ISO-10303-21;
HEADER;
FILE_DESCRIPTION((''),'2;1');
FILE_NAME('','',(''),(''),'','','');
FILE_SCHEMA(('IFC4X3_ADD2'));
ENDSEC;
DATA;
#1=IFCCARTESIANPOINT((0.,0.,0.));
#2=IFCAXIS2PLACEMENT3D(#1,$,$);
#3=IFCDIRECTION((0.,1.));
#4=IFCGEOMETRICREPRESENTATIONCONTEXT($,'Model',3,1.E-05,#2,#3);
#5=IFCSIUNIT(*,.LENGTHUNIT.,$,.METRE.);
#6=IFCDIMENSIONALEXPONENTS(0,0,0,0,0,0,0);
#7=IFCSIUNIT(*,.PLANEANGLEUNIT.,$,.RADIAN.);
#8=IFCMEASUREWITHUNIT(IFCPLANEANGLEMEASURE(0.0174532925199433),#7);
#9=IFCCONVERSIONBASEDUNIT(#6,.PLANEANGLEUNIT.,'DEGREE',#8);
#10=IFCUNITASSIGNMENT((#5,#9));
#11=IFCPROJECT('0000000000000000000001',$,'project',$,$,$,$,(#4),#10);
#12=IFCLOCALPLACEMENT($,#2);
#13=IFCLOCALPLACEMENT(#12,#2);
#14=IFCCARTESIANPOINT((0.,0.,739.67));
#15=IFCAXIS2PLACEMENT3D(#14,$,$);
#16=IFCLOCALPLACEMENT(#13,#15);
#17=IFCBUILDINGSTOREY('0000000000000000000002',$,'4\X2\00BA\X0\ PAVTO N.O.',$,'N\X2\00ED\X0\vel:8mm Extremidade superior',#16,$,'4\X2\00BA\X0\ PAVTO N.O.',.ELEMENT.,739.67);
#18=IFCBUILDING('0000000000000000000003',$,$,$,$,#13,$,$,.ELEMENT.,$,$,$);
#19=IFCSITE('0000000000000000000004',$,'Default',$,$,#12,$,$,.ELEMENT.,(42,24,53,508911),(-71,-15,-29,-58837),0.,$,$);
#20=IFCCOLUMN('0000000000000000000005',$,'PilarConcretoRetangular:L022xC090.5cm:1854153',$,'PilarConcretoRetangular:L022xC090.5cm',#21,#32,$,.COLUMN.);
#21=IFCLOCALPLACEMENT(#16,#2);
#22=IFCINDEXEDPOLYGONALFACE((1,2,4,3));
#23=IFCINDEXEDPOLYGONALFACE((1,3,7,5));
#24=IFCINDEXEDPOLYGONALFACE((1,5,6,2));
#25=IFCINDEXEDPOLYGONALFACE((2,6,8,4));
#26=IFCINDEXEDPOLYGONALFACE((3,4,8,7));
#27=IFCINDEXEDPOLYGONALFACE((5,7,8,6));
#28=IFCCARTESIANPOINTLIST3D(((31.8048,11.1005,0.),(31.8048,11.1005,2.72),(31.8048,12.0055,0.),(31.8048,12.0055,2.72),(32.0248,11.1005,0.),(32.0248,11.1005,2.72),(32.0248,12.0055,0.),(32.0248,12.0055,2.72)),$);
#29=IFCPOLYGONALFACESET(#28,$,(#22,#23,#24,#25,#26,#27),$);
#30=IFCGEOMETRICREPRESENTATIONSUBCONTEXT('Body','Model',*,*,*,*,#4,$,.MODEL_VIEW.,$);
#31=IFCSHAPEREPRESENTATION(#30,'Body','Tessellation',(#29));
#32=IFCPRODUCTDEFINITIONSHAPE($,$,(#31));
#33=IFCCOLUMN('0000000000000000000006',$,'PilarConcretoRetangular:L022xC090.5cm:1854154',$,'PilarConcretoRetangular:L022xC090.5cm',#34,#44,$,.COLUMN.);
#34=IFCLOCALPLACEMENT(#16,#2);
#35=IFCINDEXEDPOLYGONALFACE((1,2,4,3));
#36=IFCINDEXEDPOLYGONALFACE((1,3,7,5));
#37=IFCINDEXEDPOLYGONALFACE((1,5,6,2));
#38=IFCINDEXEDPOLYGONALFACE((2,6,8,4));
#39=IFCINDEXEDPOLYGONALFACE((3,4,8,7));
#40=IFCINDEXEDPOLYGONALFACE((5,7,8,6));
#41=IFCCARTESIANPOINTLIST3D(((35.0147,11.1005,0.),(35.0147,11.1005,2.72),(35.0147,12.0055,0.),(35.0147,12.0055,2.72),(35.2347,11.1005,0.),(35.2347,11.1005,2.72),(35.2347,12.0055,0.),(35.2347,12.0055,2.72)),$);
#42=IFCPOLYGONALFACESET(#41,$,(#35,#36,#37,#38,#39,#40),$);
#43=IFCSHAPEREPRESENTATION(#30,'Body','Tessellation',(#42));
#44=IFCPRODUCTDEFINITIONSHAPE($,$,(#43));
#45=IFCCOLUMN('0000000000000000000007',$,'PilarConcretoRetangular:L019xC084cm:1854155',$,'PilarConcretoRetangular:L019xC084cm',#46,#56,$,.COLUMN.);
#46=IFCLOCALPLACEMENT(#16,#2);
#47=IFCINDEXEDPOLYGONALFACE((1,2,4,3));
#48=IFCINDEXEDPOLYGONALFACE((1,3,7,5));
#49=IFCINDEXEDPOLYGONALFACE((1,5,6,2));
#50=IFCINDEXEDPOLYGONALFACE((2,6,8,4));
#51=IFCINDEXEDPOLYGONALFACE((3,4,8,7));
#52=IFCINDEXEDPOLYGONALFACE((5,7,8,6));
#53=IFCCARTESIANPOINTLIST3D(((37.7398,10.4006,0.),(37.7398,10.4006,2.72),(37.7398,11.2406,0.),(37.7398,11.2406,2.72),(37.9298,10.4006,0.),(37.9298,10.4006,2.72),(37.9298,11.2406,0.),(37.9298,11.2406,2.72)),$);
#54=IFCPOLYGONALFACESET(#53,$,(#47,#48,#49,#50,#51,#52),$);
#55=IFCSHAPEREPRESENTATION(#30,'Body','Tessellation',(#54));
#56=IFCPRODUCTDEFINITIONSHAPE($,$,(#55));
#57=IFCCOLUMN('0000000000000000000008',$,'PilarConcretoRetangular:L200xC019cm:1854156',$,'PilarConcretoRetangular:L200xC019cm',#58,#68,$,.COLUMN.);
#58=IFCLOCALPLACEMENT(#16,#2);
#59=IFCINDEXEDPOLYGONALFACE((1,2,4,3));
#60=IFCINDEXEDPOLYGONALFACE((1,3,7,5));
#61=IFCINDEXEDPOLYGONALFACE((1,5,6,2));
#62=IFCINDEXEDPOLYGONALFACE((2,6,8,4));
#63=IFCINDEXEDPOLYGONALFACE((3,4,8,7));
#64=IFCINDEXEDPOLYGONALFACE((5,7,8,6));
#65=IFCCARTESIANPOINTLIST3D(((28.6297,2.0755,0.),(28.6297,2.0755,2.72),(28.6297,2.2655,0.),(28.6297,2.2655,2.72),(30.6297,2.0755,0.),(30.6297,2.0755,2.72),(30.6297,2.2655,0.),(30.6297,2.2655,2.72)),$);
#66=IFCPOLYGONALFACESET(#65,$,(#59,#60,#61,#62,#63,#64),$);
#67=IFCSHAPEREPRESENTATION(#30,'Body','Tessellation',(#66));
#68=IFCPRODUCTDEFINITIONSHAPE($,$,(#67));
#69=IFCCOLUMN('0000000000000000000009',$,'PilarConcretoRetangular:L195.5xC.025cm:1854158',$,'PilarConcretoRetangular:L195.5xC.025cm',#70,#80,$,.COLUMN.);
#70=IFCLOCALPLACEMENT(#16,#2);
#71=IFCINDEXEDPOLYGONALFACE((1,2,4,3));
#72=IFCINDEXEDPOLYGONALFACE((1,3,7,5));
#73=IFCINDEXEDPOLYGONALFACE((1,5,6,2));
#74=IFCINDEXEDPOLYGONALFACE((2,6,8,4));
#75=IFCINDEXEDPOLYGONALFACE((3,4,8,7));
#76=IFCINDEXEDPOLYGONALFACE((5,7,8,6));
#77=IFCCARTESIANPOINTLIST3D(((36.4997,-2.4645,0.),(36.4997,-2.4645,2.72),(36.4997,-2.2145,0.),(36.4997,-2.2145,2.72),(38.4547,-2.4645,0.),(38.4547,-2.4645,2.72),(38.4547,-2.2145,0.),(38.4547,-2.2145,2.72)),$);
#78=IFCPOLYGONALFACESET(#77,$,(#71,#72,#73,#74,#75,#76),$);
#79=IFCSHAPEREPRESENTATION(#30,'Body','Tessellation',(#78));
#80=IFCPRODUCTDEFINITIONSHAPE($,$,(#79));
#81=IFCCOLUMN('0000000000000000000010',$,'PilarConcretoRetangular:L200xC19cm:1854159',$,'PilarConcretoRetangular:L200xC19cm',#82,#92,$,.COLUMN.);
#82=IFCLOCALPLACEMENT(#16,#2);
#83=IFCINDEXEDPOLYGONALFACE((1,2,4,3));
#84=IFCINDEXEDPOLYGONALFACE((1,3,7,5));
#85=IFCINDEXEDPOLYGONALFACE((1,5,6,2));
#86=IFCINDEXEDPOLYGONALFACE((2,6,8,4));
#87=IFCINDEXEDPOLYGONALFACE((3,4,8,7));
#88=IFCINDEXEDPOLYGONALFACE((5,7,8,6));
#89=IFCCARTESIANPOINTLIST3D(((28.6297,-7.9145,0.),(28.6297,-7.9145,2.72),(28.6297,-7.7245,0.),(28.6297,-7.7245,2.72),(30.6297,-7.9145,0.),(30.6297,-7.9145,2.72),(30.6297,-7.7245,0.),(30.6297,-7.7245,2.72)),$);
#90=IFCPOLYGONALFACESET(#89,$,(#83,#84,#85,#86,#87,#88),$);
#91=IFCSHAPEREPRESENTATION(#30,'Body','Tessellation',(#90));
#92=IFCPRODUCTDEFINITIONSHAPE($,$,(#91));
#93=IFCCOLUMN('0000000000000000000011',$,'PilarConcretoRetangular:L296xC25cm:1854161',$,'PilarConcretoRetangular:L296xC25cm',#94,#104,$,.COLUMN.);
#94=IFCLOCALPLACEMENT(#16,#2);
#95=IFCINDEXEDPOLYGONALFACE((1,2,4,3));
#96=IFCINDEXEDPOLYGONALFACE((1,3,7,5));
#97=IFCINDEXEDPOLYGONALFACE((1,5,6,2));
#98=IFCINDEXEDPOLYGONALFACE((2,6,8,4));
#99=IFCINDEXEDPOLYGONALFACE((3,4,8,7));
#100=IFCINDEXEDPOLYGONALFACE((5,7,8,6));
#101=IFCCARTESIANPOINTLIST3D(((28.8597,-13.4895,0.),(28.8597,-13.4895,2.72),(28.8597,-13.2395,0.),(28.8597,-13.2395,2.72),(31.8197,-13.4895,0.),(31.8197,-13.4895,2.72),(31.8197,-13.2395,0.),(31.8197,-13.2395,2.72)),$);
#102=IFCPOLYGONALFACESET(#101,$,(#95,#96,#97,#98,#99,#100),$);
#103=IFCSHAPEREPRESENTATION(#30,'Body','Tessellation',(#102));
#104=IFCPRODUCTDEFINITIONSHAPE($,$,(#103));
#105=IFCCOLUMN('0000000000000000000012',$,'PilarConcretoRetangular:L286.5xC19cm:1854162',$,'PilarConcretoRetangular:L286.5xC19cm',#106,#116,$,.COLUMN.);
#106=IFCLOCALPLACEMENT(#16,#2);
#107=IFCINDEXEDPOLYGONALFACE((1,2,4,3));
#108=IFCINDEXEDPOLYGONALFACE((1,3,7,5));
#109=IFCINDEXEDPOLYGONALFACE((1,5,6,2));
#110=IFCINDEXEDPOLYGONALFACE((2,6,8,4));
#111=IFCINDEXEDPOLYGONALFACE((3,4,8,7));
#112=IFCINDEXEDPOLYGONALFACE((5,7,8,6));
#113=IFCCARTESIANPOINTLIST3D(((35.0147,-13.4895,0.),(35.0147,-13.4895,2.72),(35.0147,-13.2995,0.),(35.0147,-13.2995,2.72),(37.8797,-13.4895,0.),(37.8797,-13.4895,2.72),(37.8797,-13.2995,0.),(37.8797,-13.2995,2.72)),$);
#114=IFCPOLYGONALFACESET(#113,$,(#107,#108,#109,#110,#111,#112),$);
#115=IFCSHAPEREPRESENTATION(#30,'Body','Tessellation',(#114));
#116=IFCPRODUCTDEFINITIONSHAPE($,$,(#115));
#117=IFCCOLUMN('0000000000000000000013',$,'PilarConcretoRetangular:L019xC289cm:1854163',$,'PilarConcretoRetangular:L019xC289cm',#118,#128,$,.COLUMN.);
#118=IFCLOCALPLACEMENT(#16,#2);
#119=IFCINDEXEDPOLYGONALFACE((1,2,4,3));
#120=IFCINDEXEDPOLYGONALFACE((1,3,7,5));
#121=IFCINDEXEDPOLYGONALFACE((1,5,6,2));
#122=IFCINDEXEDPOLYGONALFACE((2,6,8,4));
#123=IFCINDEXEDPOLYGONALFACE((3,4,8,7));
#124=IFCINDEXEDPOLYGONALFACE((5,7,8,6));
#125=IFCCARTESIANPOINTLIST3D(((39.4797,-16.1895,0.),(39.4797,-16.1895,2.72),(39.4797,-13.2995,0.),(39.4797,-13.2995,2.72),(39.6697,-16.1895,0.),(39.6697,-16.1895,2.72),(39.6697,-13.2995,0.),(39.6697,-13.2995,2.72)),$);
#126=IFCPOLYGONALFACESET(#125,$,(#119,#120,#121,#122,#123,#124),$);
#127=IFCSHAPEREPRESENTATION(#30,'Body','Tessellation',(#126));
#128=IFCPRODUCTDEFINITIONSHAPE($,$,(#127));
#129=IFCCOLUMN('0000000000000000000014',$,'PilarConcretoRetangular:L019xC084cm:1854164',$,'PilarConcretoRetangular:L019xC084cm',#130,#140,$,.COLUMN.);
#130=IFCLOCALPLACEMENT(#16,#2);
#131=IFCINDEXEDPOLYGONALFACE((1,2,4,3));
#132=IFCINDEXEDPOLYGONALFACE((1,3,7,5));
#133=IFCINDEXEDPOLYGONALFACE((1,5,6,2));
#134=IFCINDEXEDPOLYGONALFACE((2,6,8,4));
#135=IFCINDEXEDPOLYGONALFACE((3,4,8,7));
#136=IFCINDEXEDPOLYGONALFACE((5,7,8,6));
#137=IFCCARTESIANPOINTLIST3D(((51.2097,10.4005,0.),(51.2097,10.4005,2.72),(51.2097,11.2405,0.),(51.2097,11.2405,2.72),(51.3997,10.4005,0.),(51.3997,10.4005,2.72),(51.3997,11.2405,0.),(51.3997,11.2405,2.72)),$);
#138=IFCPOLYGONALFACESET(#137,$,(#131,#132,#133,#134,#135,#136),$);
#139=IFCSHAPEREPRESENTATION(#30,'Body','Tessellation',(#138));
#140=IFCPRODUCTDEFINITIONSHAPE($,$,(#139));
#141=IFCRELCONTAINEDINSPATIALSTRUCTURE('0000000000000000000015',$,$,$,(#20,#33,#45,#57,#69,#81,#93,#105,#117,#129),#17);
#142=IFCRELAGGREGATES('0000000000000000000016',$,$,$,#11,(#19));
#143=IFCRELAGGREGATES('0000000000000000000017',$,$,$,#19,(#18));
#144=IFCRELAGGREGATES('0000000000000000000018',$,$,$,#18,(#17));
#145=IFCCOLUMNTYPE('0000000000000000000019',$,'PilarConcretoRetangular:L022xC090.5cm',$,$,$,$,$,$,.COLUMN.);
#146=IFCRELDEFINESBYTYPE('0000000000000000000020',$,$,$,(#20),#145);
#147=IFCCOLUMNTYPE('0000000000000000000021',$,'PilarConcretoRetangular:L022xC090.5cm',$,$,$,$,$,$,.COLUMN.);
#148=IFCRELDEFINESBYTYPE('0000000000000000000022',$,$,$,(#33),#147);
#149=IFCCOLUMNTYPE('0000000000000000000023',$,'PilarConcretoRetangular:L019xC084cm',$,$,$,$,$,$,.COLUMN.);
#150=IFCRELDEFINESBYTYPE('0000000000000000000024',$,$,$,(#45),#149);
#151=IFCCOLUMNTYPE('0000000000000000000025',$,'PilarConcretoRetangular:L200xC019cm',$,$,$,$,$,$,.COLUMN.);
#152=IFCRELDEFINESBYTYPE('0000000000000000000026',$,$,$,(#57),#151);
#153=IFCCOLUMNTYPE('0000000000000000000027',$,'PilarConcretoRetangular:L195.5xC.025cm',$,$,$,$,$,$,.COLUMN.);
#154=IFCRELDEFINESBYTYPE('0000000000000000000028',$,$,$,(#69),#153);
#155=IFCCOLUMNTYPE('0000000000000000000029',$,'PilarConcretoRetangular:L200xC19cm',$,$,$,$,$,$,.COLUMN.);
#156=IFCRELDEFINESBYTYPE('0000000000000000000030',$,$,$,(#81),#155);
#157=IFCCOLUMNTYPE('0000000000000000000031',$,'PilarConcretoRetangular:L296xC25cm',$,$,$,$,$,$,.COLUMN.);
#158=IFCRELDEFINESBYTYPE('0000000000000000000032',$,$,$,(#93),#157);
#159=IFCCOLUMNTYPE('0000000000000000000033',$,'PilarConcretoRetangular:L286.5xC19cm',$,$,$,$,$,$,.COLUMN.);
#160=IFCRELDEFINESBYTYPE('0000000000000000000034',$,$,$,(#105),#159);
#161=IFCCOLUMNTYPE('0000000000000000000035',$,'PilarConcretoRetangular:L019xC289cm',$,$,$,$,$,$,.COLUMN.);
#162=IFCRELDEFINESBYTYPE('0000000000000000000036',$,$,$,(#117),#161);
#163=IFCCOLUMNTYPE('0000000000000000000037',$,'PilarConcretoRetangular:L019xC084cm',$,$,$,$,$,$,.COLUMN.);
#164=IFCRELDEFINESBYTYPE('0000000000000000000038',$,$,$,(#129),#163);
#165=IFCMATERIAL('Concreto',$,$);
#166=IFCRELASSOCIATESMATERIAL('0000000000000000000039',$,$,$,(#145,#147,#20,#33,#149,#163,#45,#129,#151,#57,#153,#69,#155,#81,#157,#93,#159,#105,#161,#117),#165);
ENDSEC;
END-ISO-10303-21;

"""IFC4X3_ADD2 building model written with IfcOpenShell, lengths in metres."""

from ifc_helpers import new_model, entity, si_unit, converted_unit, direction, frame, frame_2d, origin, origin_2d_with_axis, place, context, subcontext, project, spatial, rectangle, extrude, source, transform, mapped, material, material_profile, profile_set, profile_usage, type_object, type_shapes, element, save


model = new_model("IFC4X3_ADD2")

# Units and contexts
model_context = context("Model", 3, precision=1e-05, world=origin(), true_north=direction((0.0, 1.0)))
body_context = subcontext(model_context, "Body", "Model", "MODEL_VIEW")
ifc_project = project(units=[si_unit("LENGTHUNIT", "METRE"), converted_unit("PLANEANGLEUNIT", "DEGREE", entity("IfcPlaneAngleMeasure", 0.0174532925199433), si_unit("PLANEANGLEUNIT", "RADIAN"), dimensions=[0, 0, 0, 0, 0, 0, 0])], contexts=[model_context])

# Site, building, storey
site_placement = place(None, origin())
site = spatial("IfcSite", under=ifc_project, at=site_placement, Name="Default", CompositionType="ELEMENT", RefLatitude=(42, 24, 53, 508911), RefLongitude=(-71, -15, -29, -58837), RefElevation=0.0)
building_placement = place(site_placement, origin())
building = spatial("IfcBuilding", under=site, at=building_placement, CompositionType="ELEMENT")
storey_placement = place(building_placement, frame((0.0, 0.0, 739.67)))
storey = spatial("IfcBuildingStorey", under=building, at=storey_placement, Name="4º PAVTO N.O.", ObjectType="Nível:8mm Extremidade superior", LongName="4º PAVTO N.O.", CompositionType="ELEMENT", Elevation=739.67)

# Columns
ifc_material = material(Name="Concreto")
ifc_material_profile_1 = material_profile(ifc_material, rectangle(XDim=0.22, YDim=0.905, at=frame_2d((0.0, 0.0), x_axis=(1.0, 0.0))), Name="L022xC090.5cm")
ifc_profile_set_1 = profile_set([ifc_material_profile_1], Name="L022xC090.5cm")
ifc_profile_usage_1 = profile_usage(ifc_profile_set_1)
column_type_1 = type_object("IfcColumnType", Name="PilarConcretoRetangular:L022xC090.5cm", PredefinedType="COLUMN", material=ifc_profile_set_1)
shared_shape_1 = source(origin(), body_context, "Body", "SweptSolid", [
    extrude(rectangle(XDim=0.22, YDim=0.905, at=frame_2d((0.0, 0.0), x_axis=(1.0, 0.0))), frame((31.9148, 11.553, 739.67), z_axis=(0.0, 0.0, 1.0), x_axis=(-1.0, 0.0, 0.0)), (0.0, 0.0, 1.0), 2.72),
])
type_shapes(column_type_1, [shared_shape_1])
column_1_placement = place(storey_placement, frame((0.0, 0.0, -739.67)))
element("IfcColumn", 1, at=column_1_placement, inside=storey, type_object=column_type_1, material=ifc_profile_usage_1, Name="PilarConcretoRetangular:L022xC090.5cm:1854153", ObjectType="PilarConcretoRetangular:L022xC090.5cm", PredefinedType="COLUMN", context=body_context, shape_type="MappedRepresentation", body=[
    mapped(shared_shape_1, transform((0.0, 0.0, 0.0), scale=1.0)),
])
column_type_2 = type_object("IfcColumnType", Name="PilarConcretoRetangular:L022xC090.5cm", PredefinedType="COLUMN", material=ifc_profile_set_1)
shared_shape_2 = source(origin(), body_context, "Body", "SweptSolid", [
    extrude(rectangle(XDim=0.22, YDim=0.905, at=frame_2d((0.0, 0.0), x_axis=(1.0, 0.0))), frame((35.1247, 11.553, 739.67), z_axis=(0.0, 0.0, 1.0), x_axis=(-1.0, 0.0, 0.0)), (0.0, 0.0, 1.0), 2.72),
])
type_shapes(column_type_2, [shared_shape_2])
column_2_placement = place(storey_placement, frame((0.0, 0.0, -739.67)))
element("IfcColumn", 2, at=column_2_placement, inside=storey, type_object=column_type_2, material=ifc_profile_usage_1, Name="PilarConcretoRetangular:L022xC090.5cm:1854154", ObjectType="PilarConcretoRetangular:L022xC090.5cm", PredefinedType="COLUMN", context=body_context, shape_type="MappedRepresentation", body=[
    mapped(shared_shape_2, transform((0.0, 0.0, 0.0), scale=1.0)),
])
ifc_material_profile_2 = material_profile(ifc_material, rectangle(XDim=0.19, YDim=0.84, at=frame_2d((0.0, 0.0), x_axis=(1.0, 0.0))), Name="L019xC084cm")
ifc_profile_set_2 = profile_set([ifc_material_profile_2], Name="L019xC084cm")
ifc_profile_usage_2 = profile_usage(ifc_profile_set_2)
column_type_3 = type_object("IfcColumnType", Name="PilarConcretoRetangular:L019xC084cm", PredefinedType="COLUMN", material=ifc_profile_set_2)
shared_shape_3 = source(origin(), body_context, "Body", "SweptSolid", [
    extrude(rectangle(XDim=0.19, YDim=0.84, at=origin_2d_with_axis()), frame((37.8348, 10.8206, 739.67), z_axis=(0.0, 0.0, 1.0), x_axis=(-1.0, 0.0, 0.0)), (0.0, 0.0, 1.0), 2.72),
])
type_shapes(column_type_3, [shared_shape_3])
column_3_placement = place(storey_placement, frame((0.0, 0.0, -739.67)))
element("IfcColumn", 3, at=column_3_placement, inside=storey, type_object=column_type_3, material=ifc_profile_usage_2, Name="PilarConcretoRetangular:L019xC084cm:1854155", ObjectType="PilarConcretoRetangular:L019xC084cm", PredefinedType="COLUMN", context=body_context, shape_type="MappedRepresentation", body=[
    mapped(shared_shape_3, transform((0.0, 0.0, 0.0), scale=1.0)),
])
ifc_material_profile_3 = material_profile(ifc_material, rectangle(XDim=2.0, YDim=0.19, at=frame_2d((0.0, 0.0), x_axis=(1.0, 0.0))), Name="L200xC019cm")
ifc_profile_set_3 = profile_set([ifc_material_profile_3], Name="L200xC019cm")
ifc_profile_usage_3 = profile_usage(ifc_profile_set_3)
column_type_4 = type_object("IfcColumnType", Name="PilarConcretoRetangular:L200xC019cm", PredefinedType="COLUMN", material=ifc_profile_set_3)
shared_shape_4 = source(origin(), body_context, "Body", "SweptSolid", [
    extrude(rectangle(XDim=2.0, YDim=0.19, at=frame_2d((0.0, 0.0), x_axis=(1.0, 0.0))), frame((29.6297, 2.1705, 739.67)), (0.0, 0.0, 1.0), 2.72),
])
type_shapes(column_type_4, [shared_shape_4])
column_4_placement = place(storey_placement, frame((0.0, 0.0, -739.67)))
element("IfcColumn", 4, at=column_4_placement, inside=storey, type_object=column_type_4, material=ifc_profile_usage_3, Name="PilarConcretoRetangular:L200xC019cm:1854156", ObjectType="PilarConcretoRetangular:L200xC019cm", PredefinedType="COLUMN", context=body_context, shape_type="MappedRepresentation", body=[
    mapped(shared_shape_4, transform((0.0, 0.0, 0.0), scale=1.0)),
])
ifc_material_profile_4 = material_profile(ifc_material, rectangle(XDim=1.955, YDim=0.25, at=frame_2d((0.0, 0.0), x_axis=(1.0, 0.0))), Name="L195.5xC.025cm")
ifc_profile_set_4 = profile_set([ifc_material_profile_4], Name="L195.5xC.025cm")
ifc_profile_usage_4 = profile_usage(ifc_profile_set_4)
column_type_5 = type_object("IfcColumnType", Name="PilarConcretoRetangular:L195.5xC.025cm", PredefinedType="COLUMN", material=ifc_profile_set_4)
shared_shape_5 = source(origin(), body_context, "Body", "SweptSolid", [
    extrude(rectangle(XDim=1.955, YDim=0.25, at=frame_2d((0.0, 0.0), x_axis=(1.0, 0.0))), frame((37.4772, -2.3395, 739.67)), (0.0, 0.0, 1.0), 2.72),
])
type_shapes(column_type_5, [shared_shape_5])
column_5_placement = place(storey_placement, frame((0.0, 0.0, -739.67)))
element("IfcColumn", 5, at=column_5_placement, inside=storey, type_object=column_type_5, material=ifc_profile_usage_4, Name="PilarConcretoRetangular:L195.5xC.025cm:1854158", ObjectType="PilarConcretoRetangular:L195.5xC.025cm", PredefinedType="COLUMN", context=body_context, shape_type="MappedRepresentation", body=[
    mapped(shared_shape_5, transform((0.0, 0.0, 0.0), scale=1.0)),
])
ifc_material_profile_5 = material_profile(ifc_material, rectangle(XDim=2.0, YDim=0.19, at=frame_2d((0.0, 0.0), x_axis=(1.0, 0.0))), Name="L200xC19cm")
ifc_profile_set_5 = profile_set([ifc_material_profile_5], Name="L200xC19cm")
ifc_profile_usage_5 = profile_usage(ifc_profile_set_5)
column_type_6 = type_object("IfcColumnType", Name="PilarConcretoRetangular:L200xC19cm", PredefinedType="COLUMN", material=ifc_profile_set_5)
shared_shape_6 = source(origin(), body_context, "Body", "SweptSolid", [
    extrude(rectangle(XDim=2.0, YDim=0.19, at=frame_2d((0.0, 0.0), x_axis=(1.0, 0.0))), frame((29.6297, -7.8195, 739.67)), (0.0, 0.0, 1.0), 2.72),
])
type_shapes(column_type_6, [shared_shape_6])
column_6_placement = place(storey_placement, frame((0.0, 0.0, -739.67)))
element("IfcColumn", 6, at=column_6_placement, inside=storey, type_object=column_type_6, material=ifc_profile_usage_5, Name="PilarConcretoRetangular:L200xC19cm:1854159", ObjectType="PilarConcretoRetangular:L200xC19cm", PredefinedType="COLUMN", context=body_context, shape_type="MappedRepresentation", body=[
    mapped(shared_shape_6, transform((0.0, 0.0, 0.0), scale=1.0)),
])
ifc_material_profile_6 = material_profile(ifc_material, rectangle(XDim=2.96, YDim=0.25, at=frame_2d((0.0, 0.0), x_axis=(1.0, 0.0))), Name="L296xC25cm")
ifc_profile_set_6 = profile_set([ifc_material_profile_6], Name="L296xC25cm")
ifc_profile_usage_6 = profile_usage(ifc_profile_set_6)
column_type_7 = type_object("IfcColumnType", Name="PilarConcretoRetangular:L296xC25cm", PredefinedType="COLUMN", material=ifc_profile_set_6)
shared_shape_7 = source(origin(), body_context, "Body", "SweptSolid", [
    extrude(rectangle(XDim=2.96, YDim=0.25, at=frame_2d((0.0, 0.0), x_axis=(1.0, 0.0))), frame((30.3397, -13.3645, 739.67)), (0.0, 0.0, 1.0), 2.72),
])
type_shapes(column_type_7, [shared_shape_7])
column_7_placement = place(storey_placement, frame((0.0, 0.0, -739.67)))
element("IfcColumn", 7, at=column_7_placement, inside=storey, type_object=column_type_7, material=ifc_profile_usage_6, Name="PilarConcretoRetangular:L296xC25cm:1854161", ObjectType="PilarConcretoRetangular:L296xC25cm", PredefinedType="COLUMN", context=body_context, shape_type="MappedRepresentation", body=[
    mapped(shared_shape_7, transform((0.0, 0.0, 0.0), scale=1.0)),
])
ifc_material_profile_7 = material_profile(ifc_material, rectangle(XDim=2.865, YDim=0.19, at=frame_2d((0.0, 0.0), x_axis=(1.0, 0.0))), Name="L286.5xC19cm")
ifc_profile_set_7 = profile_set([ifc_material_profile_7], Name="L286.5xC19cm")
ifc_profile_usage_7 = profile_usage(ifc_profile_set_7)
column_type_8 = type_object("IfcColumnType", Name="PilarConcretoRetangular:L286.5xC19cm", PredefinedType="COLUMN", material=ifc_profile_set_7)
shared_shape_8 = source(origin(), body_context, "Body", "SweptSolid", [
    extrude(rectangle(XDim=2.865, YDim=0.19, at=frame_2d((0.0, 0.0), x_axis=(1.0, 0.0))), frame((36.4472, -13.3945, 739.67)), (0.0, 0.0, 1.0), 2.72),
])
type_shapes(column_type_8, [shared_shape_8])
column_8_placement = place(storey_placement, frame((0.0, 0.0, -739.67)))
element("IfcColumn", 8, at=column_8_placement, inside=storey, type_object=column_type_8, material=ifc_profile_usage_7, Name="PilarConcretoRetangular:L286.5xC19cm:1854162", ObjectType="PilarConcretoRetangular:L286.5xC19cm", PredefinedType="COLUMN", context=body_context, shape_type="MappedRepresentation", body=[
    mapped(shared_shape_8, transform((0.0, 0.0, 0.0), scale=1.0)),
])
ifc_material_profile_8 = material_profile(ifc_material, rectangle(XDim=0.19, YDim=2.89, at=frame_2d((0.0, 0.0), x_axis=(1.0, 0.0))), Name="L019xC289cm")
ifc_profile_set_8 = profile_set([ifc_material_profile_8], Name="L019xC289cm")
ifc_profile_usage_8 = profile_usage(ifc_profile_set_8)
column_type_9 = type_object("IfcColumnType", Name="PilarConcretoRetangular:L019xC289cm", PredefinedType="COLUMN", material=ifc_profile_set_8)
shared_shape_9 = source(origin(), body_context, "Body", "SweptSolid", [
    extrude(rectangle(XDim=0.19, YDim=2.89, at=frame_2d((0.0, 0.0), x_axis=(1.0, 0.0))), frame((39.5747, -14.7445, 739.67), z_axis=(0.0, 0.0, 1.0), x_axis=(-1.0, 0.0, 0.0)), (0.0, 0.0, 1.0), 2.72),
])
type_shapes(column_type_9, [shared_shape_9])
column_9_placement = place(storey_placement, frame((0.0, 0.0, -739.67)))
element("IfcColumn", 9, at=column_9_placement, inside=storey, type_object=column_type_9, material=ifc_profile_usage_8, Name="PilarConcretoRetangular:L019xC289cm:1854163", ObjectType="PilarConcretoRetangular:L019xC289cm", PredefinedType="COLUMN", context=body_context, shape_type="MappedRepresentation", body=[
    mapped(shared_shape_9, transform((0.0, 0.0, 0.0), scale=1.0)),
])
column_type_10 = type_object("IfcColumnType", Name="PilarConcretoRetangular:L019xC084cm", PredefinedType="COLUMN", material=ifc_profile_set_2)
shared_shape_10 = source(origin(), body_context, "Body", "SweptSolid", [
    extrude(rectangle(XDim=0.19, YDim=0.84, at=frame_2d((0.0, 0.0), x_axis=(1.0, 0.0))), frame((51.3047, 10.8205, 739.67)), (0.0, 0.0, 1.0), 2.72),
])
type_shapes(column_type_10, [shared_shape_10])
column_10_placement = place(storey_placement, frame((0.0, 0.0, -739.67)))
element("IfcColumn", 10, at=column_10_placement, inside=storey, type_object=column_type_10, material=ifc_profile_usage_2, Name="PilarConcretoRetangular:L019xC084cm:1854164", ObjectType="PilarConcretoRetangular:L019xC084cm", PredefinedType="COLUMN", context=body_context, shape_type="MappedRepresentation", body=[
    mapped(shared_shape_10, transform((0.0, 0.0, 0.0), scale=1.0)),
])

save(model, "model.ifc")
